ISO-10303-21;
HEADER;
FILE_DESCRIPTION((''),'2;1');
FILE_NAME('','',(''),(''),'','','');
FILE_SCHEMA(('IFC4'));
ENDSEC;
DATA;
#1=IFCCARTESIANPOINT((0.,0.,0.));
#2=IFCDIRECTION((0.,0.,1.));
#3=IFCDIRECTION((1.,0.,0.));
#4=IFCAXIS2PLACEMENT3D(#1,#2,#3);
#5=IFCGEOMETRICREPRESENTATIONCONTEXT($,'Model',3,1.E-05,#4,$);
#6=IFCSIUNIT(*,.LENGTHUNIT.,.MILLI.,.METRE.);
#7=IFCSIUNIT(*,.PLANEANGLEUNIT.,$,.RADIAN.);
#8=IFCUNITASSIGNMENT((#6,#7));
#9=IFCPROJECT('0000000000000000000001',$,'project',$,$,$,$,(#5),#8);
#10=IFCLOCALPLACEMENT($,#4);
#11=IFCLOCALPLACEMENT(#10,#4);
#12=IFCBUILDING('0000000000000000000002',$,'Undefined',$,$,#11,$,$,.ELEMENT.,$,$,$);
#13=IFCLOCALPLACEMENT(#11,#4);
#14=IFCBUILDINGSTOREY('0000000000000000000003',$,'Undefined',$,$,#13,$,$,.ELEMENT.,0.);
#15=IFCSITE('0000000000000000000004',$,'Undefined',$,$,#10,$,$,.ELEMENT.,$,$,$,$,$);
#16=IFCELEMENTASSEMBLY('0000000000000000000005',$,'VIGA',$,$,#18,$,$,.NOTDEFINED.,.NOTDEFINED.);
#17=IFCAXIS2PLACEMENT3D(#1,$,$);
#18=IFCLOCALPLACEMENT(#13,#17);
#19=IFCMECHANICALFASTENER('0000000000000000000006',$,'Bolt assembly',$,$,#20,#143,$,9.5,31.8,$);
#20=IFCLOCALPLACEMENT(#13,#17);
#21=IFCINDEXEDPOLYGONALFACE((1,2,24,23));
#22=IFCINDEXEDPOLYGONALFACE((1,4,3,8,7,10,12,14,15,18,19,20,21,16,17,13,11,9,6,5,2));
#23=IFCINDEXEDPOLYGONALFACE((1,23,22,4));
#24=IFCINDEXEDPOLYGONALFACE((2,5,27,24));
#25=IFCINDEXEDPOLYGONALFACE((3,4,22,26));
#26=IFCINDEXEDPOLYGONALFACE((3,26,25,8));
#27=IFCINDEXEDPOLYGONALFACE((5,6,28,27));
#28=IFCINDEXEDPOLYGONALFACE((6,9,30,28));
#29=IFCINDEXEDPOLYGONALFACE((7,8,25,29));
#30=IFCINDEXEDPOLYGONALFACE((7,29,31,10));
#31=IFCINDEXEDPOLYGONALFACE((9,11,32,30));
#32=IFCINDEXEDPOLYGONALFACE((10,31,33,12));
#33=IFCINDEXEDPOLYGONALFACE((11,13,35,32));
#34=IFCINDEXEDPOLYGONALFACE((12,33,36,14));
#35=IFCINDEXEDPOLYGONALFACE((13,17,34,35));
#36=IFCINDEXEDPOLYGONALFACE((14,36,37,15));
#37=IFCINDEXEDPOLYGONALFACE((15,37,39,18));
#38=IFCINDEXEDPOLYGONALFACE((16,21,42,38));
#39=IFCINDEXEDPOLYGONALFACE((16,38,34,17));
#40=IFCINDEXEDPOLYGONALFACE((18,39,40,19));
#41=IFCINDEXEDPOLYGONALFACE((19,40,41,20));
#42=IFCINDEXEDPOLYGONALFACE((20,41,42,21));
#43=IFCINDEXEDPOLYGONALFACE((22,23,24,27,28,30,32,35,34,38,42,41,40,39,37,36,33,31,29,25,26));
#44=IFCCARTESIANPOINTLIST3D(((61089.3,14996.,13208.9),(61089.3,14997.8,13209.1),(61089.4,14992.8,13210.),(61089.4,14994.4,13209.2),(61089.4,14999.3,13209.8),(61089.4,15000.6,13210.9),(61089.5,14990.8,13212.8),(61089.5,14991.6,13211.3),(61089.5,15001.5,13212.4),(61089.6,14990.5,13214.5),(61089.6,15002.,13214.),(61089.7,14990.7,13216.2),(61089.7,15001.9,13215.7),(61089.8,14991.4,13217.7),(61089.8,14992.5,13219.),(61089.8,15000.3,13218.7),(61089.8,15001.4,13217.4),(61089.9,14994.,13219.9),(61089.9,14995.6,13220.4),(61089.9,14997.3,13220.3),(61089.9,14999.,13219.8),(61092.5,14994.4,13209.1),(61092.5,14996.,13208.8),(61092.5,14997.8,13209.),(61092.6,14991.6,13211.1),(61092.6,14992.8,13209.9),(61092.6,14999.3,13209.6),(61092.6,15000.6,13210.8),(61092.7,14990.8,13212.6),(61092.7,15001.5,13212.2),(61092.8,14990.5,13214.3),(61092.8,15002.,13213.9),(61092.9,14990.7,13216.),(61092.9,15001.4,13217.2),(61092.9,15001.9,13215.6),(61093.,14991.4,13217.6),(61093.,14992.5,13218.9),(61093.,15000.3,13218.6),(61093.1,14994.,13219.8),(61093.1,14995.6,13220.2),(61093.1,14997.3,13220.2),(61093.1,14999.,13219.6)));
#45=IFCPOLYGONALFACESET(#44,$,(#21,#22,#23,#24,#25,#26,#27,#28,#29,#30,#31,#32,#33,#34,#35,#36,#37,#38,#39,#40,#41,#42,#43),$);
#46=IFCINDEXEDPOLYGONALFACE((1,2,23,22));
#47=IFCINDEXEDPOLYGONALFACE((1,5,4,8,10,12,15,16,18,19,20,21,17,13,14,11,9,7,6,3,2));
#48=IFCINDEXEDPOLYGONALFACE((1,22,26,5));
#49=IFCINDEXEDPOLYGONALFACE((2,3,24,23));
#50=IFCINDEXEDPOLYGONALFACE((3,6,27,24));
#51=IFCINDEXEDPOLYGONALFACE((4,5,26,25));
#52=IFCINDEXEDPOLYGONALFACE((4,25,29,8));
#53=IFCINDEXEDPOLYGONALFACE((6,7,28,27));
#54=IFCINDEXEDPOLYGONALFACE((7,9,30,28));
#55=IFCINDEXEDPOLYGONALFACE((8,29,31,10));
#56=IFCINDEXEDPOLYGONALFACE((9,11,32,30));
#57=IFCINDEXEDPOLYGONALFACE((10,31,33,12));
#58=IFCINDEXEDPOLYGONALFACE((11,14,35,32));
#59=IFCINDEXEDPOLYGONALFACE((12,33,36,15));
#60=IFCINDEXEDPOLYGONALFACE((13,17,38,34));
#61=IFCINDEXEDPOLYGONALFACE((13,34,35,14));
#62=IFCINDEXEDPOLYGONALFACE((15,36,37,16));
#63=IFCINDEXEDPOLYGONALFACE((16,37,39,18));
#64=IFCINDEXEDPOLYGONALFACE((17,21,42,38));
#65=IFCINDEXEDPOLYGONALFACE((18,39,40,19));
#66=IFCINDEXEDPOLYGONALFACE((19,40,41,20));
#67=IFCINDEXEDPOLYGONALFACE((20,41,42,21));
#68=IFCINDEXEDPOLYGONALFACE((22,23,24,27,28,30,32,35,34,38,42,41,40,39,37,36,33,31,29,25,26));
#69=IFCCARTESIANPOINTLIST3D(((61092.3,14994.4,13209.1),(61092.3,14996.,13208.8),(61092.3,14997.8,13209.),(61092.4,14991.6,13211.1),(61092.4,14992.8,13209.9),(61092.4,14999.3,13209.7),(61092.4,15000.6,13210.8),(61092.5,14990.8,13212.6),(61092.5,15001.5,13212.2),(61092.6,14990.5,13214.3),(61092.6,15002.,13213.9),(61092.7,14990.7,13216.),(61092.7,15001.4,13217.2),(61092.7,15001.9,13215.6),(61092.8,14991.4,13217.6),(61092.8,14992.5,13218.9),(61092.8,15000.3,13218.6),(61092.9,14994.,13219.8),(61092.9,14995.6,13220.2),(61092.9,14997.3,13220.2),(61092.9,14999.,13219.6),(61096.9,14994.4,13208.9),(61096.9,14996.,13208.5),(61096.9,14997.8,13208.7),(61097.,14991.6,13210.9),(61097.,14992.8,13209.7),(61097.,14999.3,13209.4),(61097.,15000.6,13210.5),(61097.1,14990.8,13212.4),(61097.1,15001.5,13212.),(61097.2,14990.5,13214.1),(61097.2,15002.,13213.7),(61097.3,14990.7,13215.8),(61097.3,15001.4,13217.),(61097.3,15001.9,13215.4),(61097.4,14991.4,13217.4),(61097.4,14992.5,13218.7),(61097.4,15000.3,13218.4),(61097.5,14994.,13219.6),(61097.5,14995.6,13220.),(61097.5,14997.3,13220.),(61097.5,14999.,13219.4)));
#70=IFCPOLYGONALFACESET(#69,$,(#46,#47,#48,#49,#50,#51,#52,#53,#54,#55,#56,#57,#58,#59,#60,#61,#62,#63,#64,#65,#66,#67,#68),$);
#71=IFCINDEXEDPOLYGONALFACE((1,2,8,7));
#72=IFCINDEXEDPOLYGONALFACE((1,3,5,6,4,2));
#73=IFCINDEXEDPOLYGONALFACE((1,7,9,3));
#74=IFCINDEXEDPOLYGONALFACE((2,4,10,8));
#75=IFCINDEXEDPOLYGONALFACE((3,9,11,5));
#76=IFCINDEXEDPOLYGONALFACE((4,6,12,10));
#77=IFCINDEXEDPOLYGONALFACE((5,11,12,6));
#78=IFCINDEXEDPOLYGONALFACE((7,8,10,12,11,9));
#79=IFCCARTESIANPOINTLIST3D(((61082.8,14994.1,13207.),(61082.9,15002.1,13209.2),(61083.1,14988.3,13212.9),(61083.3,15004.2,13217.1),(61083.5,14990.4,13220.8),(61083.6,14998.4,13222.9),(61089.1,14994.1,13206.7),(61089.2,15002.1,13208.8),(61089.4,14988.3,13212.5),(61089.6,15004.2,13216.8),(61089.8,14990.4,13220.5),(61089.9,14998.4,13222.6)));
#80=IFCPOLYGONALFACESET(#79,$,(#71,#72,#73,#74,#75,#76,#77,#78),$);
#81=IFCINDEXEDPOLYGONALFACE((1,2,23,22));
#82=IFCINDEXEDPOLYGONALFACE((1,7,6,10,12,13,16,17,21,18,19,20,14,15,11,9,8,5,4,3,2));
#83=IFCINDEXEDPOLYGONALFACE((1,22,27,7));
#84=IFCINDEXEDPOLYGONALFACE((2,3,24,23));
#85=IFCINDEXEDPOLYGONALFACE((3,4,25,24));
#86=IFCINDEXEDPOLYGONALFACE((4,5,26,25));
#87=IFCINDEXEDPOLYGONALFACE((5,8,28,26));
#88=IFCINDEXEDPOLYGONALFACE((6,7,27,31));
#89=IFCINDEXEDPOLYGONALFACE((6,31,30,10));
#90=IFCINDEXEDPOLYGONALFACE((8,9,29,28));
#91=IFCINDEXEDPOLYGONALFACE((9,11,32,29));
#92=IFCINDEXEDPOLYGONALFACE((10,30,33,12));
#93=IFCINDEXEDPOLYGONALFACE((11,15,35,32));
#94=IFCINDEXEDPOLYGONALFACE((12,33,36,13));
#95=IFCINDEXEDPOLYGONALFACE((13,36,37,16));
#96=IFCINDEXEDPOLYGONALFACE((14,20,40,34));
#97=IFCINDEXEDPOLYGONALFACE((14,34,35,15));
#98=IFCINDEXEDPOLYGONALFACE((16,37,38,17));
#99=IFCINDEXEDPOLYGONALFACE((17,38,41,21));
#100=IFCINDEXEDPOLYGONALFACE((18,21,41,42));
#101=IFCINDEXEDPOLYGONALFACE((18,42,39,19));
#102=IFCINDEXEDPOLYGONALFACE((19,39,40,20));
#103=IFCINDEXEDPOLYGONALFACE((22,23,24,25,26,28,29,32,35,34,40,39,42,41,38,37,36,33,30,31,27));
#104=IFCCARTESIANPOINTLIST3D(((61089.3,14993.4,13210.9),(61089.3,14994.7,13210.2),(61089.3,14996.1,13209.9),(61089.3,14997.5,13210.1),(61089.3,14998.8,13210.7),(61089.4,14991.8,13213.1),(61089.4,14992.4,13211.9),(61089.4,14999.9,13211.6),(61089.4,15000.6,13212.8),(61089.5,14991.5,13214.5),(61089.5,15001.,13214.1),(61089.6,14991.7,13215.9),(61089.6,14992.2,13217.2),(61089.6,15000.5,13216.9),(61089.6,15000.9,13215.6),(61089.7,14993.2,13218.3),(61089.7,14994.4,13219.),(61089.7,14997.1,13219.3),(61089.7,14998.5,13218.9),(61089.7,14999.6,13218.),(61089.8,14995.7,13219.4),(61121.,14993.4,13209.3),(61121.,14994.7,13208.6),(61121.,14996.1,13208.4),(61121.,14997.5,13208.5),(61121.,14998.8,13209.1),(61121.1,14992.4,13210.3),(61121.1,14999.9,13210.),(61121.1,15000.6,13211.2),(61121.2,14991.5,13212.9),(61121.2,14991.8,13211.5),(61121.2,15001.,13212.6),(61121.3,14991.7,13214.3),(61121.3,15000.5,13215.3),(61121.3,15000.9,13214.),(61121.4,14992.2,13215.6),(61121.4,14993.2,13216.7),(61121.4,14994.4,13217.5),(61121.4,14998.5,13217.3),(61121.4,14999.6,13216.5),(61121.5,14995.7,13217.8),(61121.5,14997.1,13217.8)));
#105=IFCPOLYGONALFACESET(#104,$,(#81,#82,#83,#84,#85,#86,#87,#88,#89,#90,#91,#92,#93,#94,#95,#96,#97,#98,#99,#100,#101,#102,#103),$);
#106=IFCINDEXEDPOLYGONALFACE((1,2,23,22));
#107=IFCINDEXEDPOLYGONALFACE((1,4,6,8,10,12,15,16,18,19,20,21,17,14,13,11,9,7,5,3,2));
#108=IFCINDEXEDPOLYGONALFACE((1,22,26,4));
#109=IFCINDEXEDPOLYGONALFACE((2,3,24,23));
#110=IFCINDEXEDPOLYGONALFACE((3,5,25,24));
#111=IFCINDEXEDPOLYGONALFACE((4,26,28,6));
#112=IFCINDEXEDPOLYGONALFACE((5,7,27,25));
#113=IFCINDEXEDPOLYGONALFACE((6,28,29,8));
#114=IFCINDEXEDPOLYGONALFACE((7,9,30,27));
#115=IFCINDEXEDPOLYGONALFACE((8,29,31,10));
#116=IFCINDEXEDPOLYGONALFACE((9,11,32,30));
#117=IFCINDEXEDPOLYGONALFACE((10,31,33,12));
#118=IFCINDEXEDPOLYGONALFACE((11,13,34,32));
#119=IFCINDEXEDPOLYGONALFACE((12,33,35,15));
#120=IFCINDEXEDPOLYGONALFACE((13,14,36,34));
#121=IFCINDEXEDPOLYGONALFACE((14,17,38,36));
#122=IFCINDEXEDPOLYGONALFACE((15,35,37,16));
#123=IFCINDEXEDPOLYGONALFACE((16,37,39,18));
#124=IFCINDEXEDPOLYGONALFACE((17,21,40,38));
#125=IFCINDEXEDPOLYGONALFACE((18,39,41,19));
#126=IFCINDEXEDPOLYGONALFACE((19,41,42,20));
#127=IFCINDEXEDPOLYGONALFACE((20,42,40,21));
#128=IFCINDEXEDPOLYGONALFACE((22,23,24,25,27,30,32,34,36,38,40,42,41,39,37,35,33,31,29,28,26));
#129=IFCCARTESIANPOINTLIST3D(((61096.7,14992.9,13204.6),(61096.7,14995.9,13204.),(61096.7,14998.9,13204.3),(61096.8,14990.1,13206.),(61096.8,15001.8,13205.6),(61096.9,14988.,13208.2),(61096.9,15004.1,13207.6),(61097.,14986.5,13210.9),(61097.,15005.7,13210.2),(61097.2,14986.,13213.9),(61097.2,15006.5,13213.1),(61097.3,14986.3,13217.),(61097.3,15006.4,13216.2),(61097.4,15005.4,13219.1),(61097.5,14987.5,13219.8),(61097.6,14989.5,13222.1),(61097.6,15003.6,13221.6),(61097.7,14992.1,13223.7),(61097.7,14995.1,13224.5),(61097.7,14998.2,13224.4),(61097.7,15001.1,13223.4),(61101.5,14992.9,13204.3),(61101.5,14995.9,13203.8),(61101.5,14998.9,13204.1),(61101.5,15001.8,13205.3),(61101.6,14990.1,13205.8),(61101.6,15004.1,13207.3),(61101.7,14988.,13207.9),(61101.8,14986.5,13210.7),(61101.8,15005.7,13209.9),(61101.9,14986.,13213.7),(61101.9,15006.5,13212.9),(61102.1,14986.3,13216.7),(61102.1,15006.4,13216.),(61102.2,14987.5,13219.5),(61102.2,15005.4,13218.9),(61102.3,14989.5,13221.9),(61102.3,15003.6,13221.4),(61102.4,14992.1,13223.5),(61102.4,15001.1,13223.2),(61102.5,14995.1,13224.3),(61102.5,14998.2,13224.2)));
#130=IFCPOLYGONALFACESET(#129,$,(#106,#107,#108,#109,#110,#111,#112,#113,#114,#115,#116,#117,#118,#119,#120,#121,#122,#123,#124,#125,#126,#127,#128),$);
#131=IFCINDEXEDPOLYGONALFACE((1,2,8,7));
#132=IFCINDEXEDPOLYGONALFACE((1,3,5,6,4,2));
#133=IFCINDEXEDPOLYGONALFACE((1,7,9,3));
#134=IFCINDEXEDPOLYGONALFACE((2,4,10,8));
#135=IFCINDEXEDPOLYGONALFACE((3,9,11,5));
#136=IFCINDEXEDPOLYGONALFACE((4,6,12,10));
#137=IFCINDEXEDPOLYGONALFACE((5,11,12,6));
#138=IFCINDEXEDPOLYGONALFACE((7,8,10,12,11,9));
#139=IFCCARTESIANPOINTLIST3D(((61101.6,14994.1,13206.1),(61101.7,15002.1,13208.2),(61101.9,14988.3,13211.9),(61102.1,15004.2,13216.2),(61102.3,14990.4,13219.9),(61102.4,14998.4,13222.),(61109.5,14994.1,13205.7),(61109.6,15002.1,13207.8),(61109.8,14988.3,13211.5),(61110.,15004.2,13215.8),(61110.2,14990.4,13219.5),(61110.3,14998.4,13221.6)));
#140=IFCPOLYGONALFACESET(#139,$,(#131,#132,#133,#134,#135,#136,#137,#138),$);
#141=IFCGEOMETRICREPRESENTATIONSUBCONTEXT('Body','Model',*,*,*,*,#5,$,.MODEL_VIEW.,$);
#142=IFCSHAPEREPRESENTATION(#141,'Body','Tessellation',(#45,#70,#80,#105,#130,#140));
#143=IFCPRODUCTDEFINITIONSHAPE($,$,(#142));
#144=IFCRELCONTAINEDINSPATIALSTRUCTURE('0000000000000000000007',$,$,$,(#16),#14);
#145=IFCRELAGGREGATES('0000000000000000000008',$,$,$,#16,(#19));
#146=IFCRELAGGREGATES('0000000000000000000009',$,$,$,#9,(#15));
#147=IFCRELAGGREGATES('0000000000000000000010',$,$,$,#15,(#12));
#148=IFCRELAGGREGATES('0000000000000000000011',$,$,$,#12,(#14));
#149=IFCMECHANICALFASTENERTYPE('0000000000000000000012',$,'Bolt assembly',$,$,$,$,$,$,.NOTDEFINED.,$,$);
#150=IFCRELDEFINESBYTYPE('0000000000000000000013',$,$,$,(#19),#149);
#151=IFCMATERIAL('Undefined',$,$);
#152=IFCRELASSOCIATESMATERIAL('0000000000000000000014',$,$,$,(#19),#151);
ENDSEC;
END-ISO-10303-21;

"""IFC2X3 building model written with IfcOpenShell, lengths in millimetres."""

from ifc_helpers import new_model, si_unit, frame, origin_with_axes, origin_2d_with_axis, place, context, subcontext, project, spatial, polyline, circle, outline, extrude, source, transform, mapped, material, type_object, element, aggregate, save


model = new_model("IFC2X3")

# Units and contexts
model_context = context("Model", 3, precision=1e-05, world=origin_with_axes())
body_context = subcontext(model_context, "Body", "Model", "MODEL_VIEW")
ifc_project = project(units=[si_unit("LENGTHUNIT", "METRE", prefix="MILLI"), si_unit("PLANEANGLEUNIT", "RADIAN")], contexts=[model_context])

# Site, building, storey
site_placement = place(None, origin_with_axes())
site = spatial("IfcSite", under=ifc_project, at=site_placement, Name="Undefined", CompositionType="ELEMENT")
building_placement = place(site_placement, origin_with_axes())
building = spatial("IfcBuilding", under=site, at=building_placement, Name="Undefined", CompositionType="ELEMENT")
storey_placement = place(building_placement, origin_with_axes())
storey = spatial("IfcBuildingStorey", under=building, at=storey_placement, Name="Undefined", CompositionType="ELEMENT", Elevation=0.0)

# Element assembly
assembly_1_placement = place(storey_placement, origin_with_axes())
assembly_1 = element("IfcElementAssembly", 1, at=assembly_1_placement, inside=storey, Name="VIGA", AssemblyPlace="NOTDEFINED", PredefinedType="NOTDEFINED")

# Shared definitions
mechanical_fastener_type = type_object("IfcMechanicalFastenerType", Name="Bolt assembly")

# Shared definitions
ifc_material_1 = material(Name="Undefined")

# Mechanical fastener
shared_shape_1 = source(origin_with_axes(), body_context, "Body", "SweptSolid", [
    extrude(circle(Radius=5.8, at=origin_2d_with_axis()), frame((0.0, -3.1, 0.0), z_axis=(0.0, 1.0, 0.0), x_axis=(1.0, 0.0, 0.0)), (0.0, 0.0, 1.0), 3.2),
    extrude(circle(Radius=5.8, at=origin_2d_with_axis()), frame((0.0, -0.1, 0.0), z_axis=(0.0, 1.0, 0.0), x_axis=(1.0, 0.0, 0.0)), (0.0, 0.0, 1.0), 4.6),
    extrude(outline(polyline([(7.1, -4.1), (7.1, 4.1), (0.0, 8.2), (-7.1, 4.1), (-7.1, -4.1), (0.0, -8.2), (7.1, -4.1)])), frame((0.0, -9.5, 0.0), z_axis=(0.0, 1.0, 0.0), x_axis=(1.0, 0.0, 0.0)), (0.0, 0.0, 1.0), 6.3),
    extrude(circle(Radius=4.8, at=origin_2d_with_axis()), frame((0.0, -3.2, 0.0), z_axis=(0.0, 1.0, 0.0), x_axis=(1.0, 0.0, 0.0)), (0.0, 0.0, 1.0), 31.8),
    extrude(circle(Radius=10.3, at=origin_2d_with_axis()), frame((0.0, 4.5, 0.0), z_axis=(0.0, 1.0, 0.0), x_axis=(1.0, 0.0, 0.0)), (0.0, 0.0, 1.0), 4.8),
    extrude(outline(polyline([(7.1, -4.1), (7.1, 4.1), (0.0, 8.2), (-7.1, 4.1), (-7.1, -4.1), (0.0, -8.2), (7.1, -4.1)])), frame((0.0, 9.3, 0.0), z_axis=(0.0, 1.0, 0.0), x_axis=(1.0, 0.0, 0.0)), (0.0, 0.0, 1.0), 7.9),
])
mechanical_fastener_1_placement = place(assembly_1_placement, frame((61092.7, 14996.3, 13214.5), z_axis=(-0.034712, 0.707107, -0.706254), x_axis=(0.034712, 0.707107, 0.706254)))
mechanical_fastener_1 = element("IfcMechanicalFastener", 2, at=mechanical_fastener_1_placement, type_object=mechanical_fastener_type, material=ifc_material_1, Name="Bolt assembly", NominalDiameter=9.5, NominalLength=31.8, context=body_context, shape_type="MappedRepresentation", body=[
    mapped(shared_shape_1, transform((0.0, 0.0, 0.0))),
])
aggregate(assembly_1, [mechanical_fastener_1])

save(model, "model.ifc")
